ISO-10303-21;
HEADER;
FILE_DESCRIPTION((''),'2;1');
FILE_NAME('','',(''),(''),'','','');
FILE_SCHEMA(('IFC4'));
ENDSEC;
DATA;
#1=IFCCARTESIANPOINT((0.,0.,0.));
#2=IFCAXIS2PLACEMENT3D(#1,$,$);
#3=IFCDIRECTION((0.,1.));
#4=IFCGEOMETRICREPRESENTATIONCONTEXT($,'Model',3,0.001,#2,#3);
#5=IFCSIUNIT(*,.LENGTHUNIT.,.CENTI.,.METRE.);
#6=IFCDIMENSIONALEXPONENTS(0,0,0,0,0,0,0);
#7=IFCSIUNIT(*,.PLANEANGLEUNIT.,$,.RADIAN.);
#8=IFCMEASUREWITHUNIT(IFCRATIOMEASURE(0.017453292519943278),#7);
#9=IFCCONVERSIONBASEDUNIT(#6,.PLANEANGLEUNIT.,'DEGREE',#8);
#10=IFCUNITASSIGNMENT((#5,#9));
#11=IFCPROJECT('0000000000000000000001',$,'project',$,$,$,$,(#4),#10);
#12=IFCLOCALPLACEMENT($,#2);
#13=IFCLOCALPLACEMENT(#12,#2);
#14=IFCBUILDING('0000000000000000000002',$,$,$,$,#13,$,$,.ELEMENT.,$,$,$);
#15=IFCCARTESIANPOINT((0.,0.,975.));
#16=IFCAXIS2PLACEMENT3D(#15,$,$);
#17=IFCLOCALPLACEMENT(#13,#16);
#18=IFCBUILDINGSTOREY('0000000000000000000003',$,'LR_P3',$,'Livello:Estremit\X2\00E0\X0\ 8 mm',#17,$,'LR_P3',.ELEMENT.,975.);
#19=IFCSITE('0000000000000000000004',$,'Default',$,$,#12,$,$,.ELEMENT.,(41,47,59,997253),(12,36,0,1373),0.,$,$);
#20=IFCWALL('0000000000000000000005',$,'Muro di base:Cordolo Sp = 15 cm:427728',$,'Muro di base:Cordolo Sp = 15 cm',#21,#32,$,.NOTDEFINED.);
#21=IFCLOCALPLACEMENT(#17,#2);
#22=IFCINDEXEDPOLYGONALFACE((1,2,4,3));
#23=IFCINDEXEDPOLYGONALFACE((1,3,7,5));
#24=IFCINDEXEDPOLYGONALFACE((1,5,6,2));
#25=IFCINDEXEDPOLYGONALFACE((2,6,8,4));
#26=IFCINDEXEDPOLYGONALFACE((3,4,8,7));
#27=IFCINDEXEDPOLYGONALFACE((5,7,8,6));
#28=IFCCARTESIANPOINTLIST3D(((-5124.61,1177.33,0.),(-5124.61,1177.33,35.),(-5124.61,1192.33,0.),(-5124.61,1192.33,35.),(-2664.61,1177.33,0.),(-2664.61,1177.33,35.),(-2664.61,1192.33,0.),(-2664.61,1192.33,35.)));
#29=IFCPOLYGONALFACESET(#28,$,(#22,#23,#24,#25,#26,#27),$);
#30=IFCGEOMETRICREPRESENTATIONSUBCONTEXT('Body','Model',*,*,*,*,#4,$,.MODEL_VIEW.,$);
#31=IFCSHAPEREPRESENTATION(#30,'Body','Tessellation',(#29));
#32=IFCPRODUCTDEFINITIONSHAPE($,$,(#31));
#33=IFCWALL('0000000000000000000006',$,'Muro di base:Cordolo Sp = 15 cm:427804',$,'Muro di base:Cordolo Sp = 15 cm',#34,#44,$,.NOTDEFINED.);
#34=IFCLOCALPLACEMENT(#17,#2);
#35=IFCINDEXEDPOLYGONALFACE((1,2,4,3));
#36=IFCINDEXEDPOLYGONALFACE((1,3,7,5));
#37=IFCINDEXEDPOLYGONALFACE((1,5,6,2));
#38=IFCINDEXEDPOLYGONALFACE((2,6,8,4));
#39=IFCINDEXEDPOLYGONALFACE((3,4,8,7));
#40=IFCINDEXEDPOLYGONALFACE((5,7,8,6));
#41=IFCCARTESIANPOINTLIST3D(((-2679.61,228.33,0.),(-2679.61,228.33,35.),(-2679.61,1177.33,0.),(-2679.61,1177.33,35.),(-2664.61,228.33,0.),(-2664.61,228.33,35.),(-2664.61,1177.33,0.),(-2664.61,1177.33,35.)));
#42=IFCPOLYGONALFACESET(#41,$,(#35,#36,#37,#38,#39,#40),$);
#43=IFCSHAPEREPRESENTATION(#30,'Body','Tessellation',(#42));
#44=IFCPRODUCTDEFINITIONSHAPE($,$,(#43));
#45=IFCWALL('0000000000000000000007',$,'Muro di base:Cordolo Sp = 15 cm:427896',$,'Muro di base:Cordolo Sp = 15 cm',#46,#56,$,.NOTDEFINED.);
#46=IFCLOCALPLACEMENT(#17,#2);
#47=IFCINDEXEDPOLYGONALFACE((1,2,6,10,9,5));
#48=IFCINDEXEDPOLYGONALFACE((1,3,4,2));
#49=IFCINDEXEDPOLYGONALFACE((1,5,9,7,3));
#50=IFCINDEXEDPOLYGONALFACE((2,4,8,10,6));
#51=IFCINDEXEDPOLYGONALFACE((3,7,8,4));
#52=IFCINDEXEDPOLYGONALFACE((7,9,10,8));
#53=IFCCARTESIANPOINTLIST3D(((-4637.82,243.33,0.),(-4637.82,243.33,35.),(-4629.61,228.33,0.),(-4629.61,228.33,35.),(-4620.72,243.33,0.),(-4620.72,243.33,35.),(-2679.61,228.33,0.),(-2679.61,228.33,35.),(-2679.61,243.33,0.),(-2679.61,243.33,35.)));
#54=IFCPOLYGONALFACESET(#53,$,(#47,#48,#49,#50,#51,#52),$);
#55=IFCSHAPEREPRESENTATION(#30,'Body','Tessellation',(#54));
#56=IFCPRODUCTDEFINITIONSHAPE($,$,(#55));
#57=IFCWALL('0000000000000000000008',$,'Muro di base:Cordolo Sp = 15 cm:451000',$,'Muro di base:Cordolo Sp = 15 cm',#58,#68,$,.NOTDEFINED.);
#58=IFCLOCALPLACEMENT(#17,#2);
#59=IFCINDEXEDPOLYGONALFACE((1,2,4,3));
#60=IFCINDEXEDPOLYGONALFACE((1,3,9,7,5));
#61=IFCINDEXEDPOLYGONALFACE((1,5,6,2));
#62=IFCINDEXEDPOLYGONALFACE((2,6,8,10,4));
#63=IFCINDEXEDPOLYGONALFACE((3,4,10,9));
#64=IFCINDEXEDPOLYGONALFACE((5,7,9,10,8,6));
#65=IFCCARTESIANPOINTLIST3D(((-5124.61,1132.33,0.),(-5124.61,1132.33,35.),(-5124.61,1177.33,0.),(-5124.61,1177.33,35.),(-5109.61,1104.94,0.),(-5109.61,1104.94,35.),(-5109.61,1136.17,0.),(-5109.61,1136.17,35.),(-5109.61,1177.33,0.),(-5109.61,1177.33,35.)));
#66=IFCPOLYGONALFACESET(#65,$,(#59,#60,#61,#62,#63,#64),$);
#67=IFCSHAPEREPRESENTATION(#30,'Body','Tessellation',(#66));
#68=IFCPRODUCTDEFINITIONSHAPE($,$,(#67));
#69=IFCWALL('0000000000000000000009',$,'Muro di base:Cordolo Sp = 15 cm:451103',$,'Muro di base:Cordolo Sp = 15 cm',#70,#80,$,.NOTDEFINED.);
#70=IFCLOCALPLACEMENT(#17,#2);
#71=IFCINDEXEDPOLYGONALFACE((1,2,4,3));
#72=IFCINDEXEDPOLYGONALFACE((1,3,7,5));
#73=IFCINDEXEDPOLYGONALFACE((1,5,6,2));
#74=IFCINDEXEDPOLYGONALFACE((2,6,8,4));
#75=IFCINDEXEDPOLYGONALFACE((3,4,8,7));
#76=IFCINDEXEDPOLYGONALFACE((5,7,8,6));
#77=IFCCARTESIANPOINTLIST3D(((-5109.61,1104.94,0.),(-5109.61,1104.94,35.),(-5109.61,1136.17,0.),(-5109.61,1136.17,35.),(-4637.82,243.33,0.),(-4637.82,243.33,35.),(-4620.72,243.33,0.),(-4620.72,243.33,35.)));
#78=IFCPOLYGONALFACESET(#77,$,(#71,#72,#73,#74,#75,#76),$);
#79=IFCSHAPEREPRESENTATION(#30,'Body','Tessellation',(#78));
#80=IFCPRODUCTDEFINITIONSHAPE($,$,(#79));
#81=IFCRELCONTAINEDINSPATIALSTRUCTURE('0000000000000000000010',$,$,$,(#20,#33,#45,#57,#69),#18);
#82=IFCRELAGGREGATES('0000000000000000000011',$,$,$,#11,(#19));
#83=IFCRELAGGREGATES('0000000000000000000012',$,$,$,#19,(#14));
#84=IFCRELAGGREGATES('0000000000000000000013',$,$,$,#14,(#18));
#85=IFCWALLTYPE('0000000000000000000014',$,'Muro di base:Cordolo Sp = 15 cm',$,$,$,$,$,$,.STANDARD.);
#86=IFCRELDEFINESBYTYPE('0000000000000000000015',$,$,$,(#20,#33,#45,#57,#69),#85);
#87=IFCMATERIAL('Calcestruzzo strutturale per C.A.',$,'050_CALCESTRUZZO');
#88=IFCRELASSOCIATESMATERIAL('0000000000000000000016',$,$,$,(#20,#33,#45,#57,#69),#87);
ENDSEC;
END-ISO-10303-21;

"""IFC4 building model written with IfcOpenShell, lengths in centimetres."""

from ifc_helpers import new_model, entity, si_unit, converted_unit, direction, frame, origin, place, context, subcontext, project, spatial, indexed_curve, outline, extrude, material, type_object, element, save


model = new_model("IFC4")

# Units and contexts
model_context = context("Model", 3, precision=0.001, world=origin(), true_north=direction((0.0, 1.0)))
body_context = subcontext(model_context, "Body", "Model", "MODEL_VIEW")
ifc_project = project(units=[si_unit("LENGTHUNIT", "METRE", prefix="CENTI"), converted_unit("PLANEANGLEUNIT", "DEGREE", entity("IfcRatioMeasure", 0.017453292519943278), si_unit("PLANEANGLEUNIT", "RADIAN"), dimensions=[0, 0, 0, 0, 0, 0, 0])], contexts=[model_context])

# Site, building, storey
site_placement = place(None, origin())
site = spatial("IfcSite", under=ifc_project, at=site_placement, Name="Default", CompositionType="ELEMENT", RefLatitude=(41, 47, 59, 997253), RefLongitude=(12, 36, 0, 1373), RefElevation=0.0)
building_placement = place(site_placement, origin())
building = spatial("IfcBuilding", under=site, at=building_placement, CompositionType="ELEMENT")
storey_placement = place(building_placement, frame((0.0, 0.0, 975.0)))
storey = spatial("IfcBuildingStorey", under=building, at=storey_placement, Name="LR_P3", ObjectType="Livello:Estremità 8 mm", LongName="LR_P3", CompositionType="ELEMENT", Elevation=975.0)

# Shared definitions
ifc_material = material(Name="Calcestruzzo strutturale per C.A.", Category="050_CALCESTRUZZO")

# Walls
wall_type = type_object("IfcWallType", Name="Muro di base:Cordolo Sp = 15 cm", PredefinedType="STANDARD")
wall_1_placement = place(storey_placement, frame((-5124.61, 1184.83, 0.0)))
element("IfcWall", 1, at=wall_1_placement, inside=storey, type_object=wall_type, material=ifc_material, Name="Muro di base:Cordolo Sp = 15 cm:427728", ObjectType="Muro di base:Cordolo Sp = 15 cm", PredefinedType="NOTDEFINED", context=body_context, shape_type="SweptSolid", body=[
    extrude(outline(indexed_curve([(2460.0, 7.5), (0.0, 7.5), (0.0, -7.5), (2460.0, -7.5), (2460.0, 7.5)], self_intersect=False)), origin(), (0.0, 0.0, 1.0), 35.0),
])
wall_2_placement = place(storey_placement, frame((-2672.11, 1177.33, 0.0), z_axis=(0.0, 0.0, 1.0), x_axis=(0.0, -1.0, 0.0)))
element("IfcWall", 2, at=wall_2_placement, inside=storey, type_object=wall_type, material=ifc_material, Name="Muro di base:Cordolo Sp = 15 cm:427804", ObjectType="Muro di base:Cordolo Sp = 15 cm", PredefinedType="NOTDEFINED", context=body_context, shape_type="SweptSolid", body=[
    extrude(outline(indexed_curve([(949.0, 7.5), (0.0, 7.5), (0.0, -7.5), (949.0, -7.5), (949.0, 7.5)], self_intersect=False)), origin(), (0.0, 0.0, 1.0), 35.0),
])
wall_3_placement = place(storey_placement, frame((-2679.61, 235.83, 0.0), z_axis=(0.0, 0.0, 1.0), x_axis=(-1.0, 0.0, 0.0)))
element("IfcWall", 3, at=wall_3_placement, inside=storey, type_object=wall_type, material=ifc_material, Name="Muro di base:Cordolo Sp = 15 cm:427896", ObjectType="Muro di base:Cordolo Sp = 15 cm", PredefinedType="NOTDEFINED", context=body_context, shape_type="SweptSolid", body=[
    extrude(outline(indexed_curve([(1958.21, -7.5), (1950.0, 7.5), (0.0, 7.5), (0.0, -7.5), (1941.11, -7.5), (1958.21, -7.5)], self_intersect=False)), origin(), (0.0, 0.0, 1.0), 35.0),
])
wall_4_placement = place(storey_placement, frame((-5117.11, 1177.33, 0.0), z_axis=(0.0, 0.0, 1.0), x_axis=(0.0, -1.0, 0.0)))
element("IfcWall", 4, at=wall_4_placement, inside=storey, type_object=wall_type, material=ifc_material, Name="Muro di base:Cordolo Sp = 15 cm:451000", ObjectType="Muro di base:Cordolo Sp = 15 cm", PredefinedType="NOTDEFINED", context=body_context, shape_type="SweptSolid", body=[
    extrude(outline(indexed_curve([(45.0, -7.5), (72.39, 7.5), (41.16, 7.5), (0.0, 7.5), (0.0, -7.5), (45.0, -7.5)], self_intersect=False)), origin(), (0.0, 0.0, 1.0), 35.0),
])
wall_5_placement = place(storey_placement, frame((-5116.19, 1132.57, 0.0), z_axis=(0.0, 0.0, 1.0), x_axis=(0.480279, -0.877116, 0.0)))
element("IfcWall", 5, at=wall_5_placement, inside=storey, type_object=wall_type, material=ifc_material, Name="Muro di base:Cordolo Sp = 15 cm:451103", ObjectType="Muro di base:Cordolo Sp = 15 cm", PredefinedType="NOTDEFINED", context=body_context, shape_type="SweptSolid", body=[
    extrude(outline(indexed_curve([(1009.71, -7.5), (1017.92, 7.5), (0.0, 7.5), (27.39, -7.5), (1009.71, -7.5)], self_intersect=False)), origin(), (0.0, 0.0, 1.0), 35.0),
])

save(model, "model.ifc")
